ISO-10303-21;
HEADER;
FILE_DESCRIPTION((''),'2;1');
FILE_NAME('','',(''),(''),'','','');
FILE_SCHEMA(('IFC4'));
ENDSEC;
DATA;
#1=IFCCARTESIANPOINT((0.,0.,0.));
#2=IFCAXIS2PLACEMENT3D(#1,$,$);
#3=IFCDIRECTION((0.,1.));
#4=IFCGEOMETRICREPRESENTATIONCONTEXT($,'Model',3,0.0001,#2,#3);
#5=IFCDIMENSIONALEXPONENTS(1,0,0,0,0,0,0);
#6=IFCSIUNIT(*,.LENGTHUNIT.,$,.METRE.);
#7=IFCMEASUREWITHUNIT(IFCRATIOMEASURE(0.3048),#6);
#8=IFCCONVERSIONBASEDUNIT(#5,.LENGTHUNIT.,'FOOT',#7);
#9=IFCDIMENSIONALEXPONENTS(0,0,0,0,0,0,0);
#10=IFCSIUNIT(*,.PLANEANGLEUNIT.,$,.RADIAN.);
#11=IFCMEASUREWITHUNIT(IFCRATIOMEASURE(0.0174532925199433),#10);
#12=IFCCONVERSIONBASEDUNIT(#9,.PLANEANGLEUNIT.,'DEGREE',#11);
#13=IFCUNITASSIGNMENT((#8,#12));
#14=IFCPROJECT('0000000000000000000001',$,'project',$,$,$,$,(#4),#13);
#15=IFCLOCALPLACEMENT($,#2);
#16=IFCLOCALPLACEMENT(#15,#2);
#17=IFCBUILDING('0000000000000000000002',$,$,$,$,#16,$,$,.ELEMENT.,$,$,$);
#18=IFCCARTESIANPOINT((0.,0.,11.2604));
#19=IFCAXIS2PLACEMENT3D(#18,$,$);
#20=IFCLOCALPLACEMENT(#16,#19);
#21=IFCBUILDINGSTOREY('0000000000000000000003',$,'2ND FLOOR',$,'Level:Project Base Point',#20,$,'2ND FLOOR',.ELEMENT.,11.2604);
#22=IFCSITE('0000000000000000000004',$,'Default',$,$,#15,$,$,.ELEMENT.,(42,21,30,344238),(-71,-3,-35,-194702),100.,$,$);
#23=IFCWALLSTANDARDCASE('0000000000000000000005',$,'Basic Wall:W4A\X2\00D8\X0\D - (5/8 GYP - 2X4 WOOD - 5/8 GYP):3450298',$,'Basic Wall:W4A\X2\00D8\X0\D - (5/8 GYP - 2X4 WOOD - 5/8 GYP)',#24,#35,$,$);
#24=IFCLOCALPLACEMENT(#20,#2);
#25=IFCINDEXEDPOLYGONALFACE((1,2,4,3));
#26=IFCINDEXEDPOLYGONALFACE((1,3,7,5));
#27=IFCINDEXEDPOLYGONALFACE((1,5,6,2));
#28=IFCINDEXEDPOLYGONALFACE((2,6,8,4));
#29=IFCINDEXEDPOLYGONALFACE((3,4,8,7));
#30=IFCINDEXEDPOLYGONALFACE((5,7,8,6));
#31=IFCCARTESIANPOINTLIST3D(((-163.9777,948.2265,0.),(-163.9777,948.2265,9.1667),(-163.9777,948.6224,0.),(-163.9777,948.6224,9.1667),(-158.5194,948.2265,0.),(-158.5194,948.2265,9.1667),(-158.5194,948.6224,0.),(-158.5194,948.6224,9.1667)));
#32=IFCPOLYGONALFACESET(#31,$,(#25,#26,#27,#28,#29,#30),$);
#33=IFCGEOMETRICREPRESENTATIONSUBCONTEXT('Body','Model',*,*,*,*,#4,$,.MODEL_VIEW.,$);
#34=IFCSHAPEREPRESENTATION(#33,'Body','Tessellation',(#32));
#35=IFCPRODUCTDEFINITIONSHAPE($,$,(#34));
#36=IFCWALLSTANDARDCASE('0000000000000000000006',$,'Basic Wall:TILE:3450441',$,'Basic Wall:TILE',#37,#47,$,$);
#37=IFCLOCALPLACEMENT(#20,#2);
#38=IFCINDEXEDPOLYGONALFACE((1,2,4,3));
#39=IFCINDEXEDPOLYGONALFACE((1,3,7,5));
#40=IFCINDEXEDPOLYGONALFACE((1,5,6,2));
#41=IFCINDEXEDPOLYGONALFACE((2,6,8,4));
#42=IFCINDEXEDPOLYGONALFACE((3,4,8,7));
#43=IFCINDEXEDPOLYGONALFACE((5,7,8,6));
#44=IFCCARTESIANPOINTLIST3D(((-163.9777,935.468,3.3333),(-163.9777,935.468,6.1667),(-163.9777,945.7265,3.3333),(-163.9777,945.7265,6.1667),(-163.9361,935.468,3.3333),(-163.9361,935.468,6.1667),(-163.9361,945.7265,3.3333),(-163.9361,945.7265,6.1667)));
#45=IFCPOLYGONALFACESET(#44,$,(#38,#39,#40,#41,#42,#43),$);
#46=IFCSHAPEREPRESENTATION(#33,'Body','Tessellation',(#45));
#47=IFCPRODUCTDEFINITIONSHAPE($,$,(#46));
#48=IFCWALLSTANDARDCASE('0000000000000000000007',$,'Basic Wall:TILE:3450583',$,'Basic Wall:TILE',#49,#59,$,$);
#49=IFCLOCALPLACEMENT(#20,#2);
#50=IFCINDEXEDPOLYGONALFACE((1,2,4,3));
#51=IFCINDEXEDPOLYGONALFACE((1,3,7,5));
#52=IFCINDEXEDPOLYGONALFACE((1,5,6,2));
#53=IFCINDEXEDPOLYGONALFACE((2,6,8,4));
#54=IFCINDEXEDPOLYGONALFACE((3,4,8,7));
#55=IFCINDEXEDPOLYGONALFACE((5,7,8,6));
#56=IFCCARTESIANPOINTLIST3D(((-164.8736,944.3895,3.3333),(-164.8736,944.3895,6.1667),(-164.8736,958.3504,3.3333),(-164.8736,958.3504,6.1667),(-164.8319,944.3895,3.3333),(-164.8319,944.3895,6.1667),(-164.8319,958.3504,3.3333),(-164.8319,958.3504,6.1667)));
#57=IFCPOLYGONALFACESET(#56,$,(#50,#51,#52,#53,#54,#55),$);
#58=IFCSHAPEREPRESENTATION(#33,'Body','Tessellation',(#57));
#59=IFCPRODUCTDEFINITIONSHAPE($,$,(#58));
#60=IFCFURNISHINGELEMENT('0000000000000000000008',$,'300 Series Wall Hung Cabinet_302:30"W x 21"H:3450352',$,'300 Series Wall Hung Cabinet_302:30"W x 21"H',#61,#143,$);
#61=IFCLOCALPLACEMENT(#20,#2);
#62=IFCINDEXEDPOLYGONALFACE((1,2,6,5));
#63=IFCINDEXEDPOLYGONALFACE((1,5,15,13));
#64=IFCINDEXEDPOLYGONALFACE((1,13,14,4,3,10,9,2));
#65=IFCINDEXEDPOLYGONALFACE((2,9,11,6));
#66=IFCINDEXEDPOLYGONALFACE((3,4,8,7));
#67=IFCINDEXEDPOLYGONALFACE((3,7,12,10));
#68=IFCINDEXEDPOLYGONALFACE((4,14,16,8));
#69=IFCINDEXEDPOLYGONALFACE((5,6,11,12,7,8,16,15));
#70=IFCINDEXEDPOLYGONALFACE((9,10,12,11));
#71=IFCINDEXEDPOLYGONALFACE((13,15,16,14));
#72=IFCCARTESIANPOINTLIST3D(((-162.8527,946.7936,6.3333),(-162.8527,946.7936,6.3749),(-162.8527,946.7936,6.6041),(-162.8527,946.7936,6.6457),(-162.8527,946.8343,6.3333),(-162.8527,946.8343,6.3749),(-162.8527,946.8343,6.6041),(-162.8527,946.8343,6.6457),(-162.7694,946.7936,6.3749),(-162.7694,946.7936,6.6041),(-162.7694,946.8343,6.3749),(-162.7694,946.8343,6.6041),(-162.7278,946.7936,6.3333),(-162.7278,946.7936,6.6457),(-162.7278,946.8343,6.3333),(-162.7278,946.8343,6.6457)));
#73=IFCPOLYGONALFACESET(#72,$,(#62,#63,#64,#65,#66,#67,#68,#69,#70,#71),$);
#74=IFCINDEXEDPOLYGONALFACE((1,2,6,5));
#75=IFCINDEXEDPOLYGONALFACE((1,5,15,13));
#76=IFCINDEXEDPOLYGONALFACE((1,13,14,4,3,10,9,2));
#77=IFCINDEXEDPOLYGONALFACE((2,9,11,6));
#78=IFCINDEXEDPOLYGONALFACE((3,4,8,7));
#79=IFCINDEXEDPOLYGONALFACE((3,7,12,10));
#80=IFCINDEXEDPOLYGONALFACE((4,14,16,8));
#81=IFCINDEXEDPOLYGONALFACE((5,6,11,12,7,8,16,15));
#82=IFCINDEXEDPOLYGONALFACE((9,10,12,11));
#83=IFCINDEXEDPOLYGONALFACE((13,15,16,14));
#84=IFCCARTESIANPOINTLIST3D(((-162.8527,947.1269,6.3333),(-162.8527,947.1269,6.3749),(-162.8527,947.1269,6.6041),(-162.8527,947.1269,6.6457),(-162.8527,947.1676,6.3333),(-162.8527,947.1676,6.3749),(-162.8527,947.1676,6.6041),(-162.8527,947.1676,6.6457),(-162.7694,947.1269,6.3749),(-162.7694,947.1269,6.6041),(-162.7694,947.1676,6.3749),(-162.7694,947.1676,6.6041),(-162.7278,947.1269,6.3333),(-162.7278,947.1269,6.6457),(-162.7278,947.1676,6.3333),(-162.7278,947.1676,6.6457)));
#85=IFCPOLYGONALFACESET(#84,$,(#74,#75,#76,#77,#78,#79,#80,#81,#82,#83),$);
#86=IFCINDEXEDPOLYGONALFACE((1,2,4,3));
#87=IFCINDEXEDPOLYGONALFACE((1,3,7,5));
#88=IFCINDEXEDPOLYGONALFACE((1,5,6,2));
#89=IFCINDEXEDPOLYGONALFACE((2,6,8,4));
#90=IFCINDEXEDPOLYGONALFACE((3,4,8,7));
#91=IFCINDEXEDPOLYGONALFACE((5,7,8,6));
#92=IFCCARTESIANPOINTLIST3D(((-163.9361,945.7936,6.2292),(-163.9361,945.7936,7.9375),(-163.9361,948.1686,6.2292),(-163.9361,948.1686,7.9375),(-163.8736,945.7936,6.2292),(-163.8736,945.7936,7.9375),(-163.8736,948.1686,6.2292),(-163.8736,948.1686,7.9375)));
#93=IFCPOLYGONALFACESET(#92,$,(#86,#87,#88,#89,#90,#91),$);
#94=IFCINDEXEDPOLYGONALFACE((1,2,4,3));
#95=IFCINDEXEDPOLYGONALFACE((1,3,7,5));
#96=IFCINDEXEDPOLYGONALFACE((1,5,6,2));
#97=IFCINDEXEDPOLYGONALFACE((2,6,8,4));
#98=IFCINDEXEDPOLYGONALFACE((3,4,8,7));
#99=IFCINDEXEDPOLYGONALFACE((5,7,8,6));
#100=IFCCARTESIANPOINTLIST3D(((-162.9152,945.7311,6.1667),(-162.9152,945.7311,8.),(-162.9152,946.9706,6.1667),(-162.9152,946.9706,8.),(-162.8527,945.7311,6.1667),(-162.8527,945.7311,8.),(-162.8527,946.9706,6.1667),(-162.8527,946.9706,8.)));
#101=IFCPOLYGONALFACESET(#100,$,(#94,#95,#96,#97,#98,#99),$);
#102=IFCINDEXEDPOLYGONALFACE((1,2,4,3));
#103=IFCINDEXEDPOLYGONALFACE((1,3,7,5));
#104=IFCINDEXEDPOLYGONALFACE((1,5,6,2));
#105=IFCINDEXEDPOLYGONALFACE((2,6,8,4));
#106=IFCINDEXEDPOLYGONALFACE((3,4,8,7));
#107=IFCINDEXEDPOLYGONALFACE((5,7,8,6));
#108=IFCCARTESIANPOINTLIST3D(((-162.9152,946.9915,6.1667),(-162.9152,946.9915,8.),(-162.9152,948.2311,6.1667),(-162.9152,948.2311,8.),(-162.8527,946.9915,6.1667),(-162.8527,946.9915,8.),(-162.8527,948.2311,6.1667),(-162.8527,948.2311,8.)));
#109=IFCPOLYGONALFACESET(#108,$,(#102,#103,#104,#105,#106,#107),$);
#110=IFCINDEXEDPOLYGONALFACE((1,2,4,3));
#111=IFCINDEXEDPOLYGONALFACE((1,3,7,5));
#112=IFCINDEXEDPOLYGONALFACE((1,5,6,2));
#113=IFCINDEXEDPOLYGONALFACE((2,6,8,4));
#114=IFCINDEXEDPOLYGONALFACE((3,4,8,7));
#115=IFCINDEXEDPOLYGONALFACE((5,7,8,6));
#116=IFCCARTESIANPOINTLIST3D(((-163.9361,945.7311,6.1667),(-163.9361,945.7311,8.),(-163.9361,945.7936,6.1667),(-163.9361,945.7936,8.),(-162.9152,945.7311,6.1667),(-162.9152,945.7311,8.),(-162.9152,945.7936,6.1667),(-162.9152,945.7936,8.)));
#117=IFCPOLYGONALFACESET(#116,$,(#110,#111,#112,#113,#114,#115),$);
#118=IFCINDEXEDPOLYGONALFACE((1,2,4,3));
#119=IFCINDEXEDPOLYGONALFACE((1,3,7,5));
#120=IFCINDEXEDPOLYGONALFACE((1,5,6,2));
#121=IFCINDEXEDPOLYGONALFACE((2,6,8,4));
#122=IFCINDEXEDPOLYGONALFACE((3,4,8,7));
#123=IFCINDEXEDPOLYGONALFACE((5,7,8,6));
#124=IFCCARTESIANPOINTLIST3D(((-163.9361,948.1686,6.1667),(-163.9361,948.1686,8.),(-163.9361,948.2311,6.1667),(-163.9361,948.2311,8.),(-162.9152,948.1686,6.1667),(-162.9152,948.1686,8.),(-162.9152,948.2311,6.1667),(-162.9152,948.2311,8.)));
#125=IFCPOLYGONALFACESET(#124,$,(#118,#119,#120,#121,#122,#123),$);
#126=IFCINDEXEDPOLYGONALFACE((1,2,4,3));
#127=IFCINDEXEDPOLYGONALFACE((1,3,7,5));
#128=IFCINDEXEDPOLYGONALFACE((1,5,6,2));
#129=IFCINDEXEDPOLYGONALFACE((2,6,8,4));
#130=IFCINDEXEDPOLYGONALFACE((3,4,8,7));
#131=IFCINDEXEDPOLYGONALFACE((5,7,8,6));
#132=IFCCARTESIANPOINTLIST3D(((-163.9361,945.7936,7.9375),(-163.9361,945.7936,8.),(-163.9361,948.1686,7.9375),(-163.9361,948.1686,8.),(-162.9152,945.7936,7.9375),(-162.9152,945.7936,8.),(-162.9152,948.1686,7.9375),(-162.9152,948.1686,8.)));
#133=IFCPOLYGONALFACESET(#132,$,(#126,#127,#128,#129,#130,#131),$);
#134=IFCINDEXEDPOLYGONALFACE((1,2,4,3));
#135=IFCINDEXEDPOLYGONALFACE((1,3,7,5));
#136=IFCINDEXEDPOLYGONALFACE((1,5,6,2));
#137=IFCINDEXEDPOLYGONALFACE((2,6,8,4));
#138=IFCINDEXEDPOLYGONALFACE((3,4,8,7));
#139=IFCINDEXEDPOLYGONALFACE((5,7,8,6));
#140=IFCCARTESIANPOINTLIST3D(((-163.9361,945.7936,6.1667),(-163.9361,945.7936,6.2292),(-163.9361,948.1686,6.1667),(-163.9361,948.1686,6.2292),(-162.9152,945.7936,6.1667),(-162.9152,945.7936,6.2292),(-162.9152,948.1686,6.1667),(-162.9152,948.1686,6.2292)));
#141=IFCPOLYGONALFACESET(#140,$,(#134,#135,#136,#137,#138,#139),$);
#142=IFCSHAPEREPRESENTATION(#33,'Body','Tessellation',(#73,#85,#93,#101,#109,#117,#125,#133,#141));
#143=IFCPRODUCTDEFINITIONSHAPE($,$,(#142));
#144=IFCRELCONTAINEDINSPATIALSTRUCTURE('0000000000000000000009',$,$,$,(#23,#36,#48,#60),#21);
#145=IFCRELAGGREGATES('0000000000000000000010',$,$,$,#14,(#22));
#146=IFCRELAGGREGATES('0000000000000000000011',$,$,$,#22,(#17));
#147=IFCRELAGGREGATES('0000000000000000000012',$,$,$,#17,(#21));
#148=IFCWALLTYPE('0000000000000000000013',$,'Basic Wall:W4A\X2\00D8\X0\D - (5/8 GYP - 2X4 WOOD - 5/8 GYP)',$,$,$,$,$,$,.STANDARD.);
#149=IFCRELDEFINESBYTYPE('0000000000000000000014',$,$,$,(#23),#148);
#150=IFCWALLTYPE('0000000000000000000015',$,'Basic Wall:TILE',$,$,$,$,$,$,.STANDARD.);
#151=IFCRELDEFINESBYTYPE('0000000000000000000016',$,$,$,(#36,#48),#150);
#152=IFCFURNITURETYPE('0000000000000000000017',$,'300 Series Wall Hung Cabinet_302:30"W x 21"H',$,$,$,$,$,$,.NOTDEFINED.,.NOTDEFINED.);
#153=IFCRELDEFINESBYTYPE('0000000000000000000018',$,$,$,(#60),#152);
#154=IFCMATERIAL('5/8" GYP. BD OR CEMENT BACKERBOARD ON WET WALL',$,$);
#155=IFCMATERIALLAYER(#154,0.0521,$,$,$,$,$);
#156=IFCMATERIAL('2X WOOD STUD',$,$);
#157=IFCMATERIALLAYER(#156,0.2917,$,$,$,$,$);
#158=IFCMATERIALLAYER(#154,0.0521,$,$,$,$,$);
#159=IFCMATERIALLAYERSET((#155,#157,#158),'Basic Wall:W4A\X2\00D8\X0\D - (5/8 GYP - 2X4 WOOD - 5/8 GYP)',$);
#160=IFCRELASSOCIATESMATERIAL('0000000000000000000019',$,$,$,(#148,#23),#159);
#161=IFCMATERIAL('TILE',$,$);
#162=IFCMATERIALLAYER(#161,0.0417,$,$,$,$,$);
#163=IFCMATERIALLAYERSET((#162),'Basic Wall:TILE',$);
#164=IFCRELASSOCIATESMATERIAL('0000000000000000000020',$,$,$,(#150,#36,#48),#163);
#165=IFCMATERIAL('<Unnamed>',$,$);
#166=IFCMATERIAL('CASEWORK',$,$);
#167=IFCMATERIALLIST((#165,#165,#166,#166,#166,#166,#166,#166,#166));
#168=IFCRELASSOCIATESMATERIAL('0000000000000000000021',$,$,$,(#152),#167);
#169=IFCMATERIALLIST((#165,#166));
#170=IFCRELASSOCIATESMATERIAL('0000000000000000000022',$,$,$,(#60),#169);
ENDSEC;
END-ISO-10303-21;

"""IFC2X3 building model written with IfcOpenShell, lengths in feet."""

from ifc_helpers import new_model, entity, si_unit, converted_unit, direction, frame, frame_2d, origin, origin_2d_with_axis, place, context, subcontext, project, spatial, polyline, rectangle, outline, extrude, source, transform, mapped, material, material_list, layer, layer_set, layer_usage, type_object, type_shapes, element, save


model = new_model("IFC2X3")

# Units and contexts
model_context = context("Model", 3, precision=0.0001, world=origin(), true_north=direction((0.0, 1.0)))
body_context = subcontext(model_context, "Body", "Model", "MODEL_VIEW")
ifc_project = project(units=[converted_unit("LENGTHUNIT", "FOOT", entity("IfcRatioMeasure", 0.3048), si_unit("LENGTHUNIT", "METRE"), dimensions=[1, 0, 0, 0, 0, 0, 0]), converted_unit("PLANEANGLEUNIT", "DEGREE", entity("IfcRatioMeasure", 0.0174532925199433), si_unit("PLANEANGLEUNIT", "RADIAN"), dimensions=[0, 0, 0, 0, 0, 0, 0])], contexts=[model_context])

# Site, building, storey
site_placement = place(None, origin())
site = spatial("IfcSite", under=ifc_project, at=site_placement, Name="Default", CompositionType="ELEMENT", RefLatitude=(42, 21, 30, 344238), RefLongitude=(-71, -3, -35, -194702), RefElevation=100.0)
building_placement = place(site_placement, origin())
building = spatial("IfcBuilding", under=site, at=building_placement, CompositionType="ELEMENT")
storey_placement = place(building_placement, frame((0.0, 0.0, 11.2604)))
storey = spatial("IfcBuildingStorey", under=building, at=storey_placement, Name="2ND FLOOR", ObjectType="Level:Project Base Point", LongName="2ND FLOOR", CompositionType="ELEMENT", Elevation=11.2604)

# Shared definitions
ifc_material_1 = material(Name="5/8\" GYP. BD OR CEMENT BACKERBOARD ON WET WALL")
ifc_layer_1 = layer(ifc_material_1, 0.0521)
ifc_material_2 = material(Name="2X WOOD STUD")
ifc_layer_2 = layer(ifc_material_2, 0.2917)
ifc_layer_3 = layer(ifc_material_1, 0.0521)
ifc_layer_set_1 = layer_set([ifc_layer_1, ifc_layer_2, ifc_layer_3], Name="Basic Wall:W4AØD - (5/8 GYP - 2X4 WOOD - 5/8 GYP)")
wall_type_1 = type_object("IfcWallType", Name="Basic Wall:W4AØD - (5/8 GYP - 2X4 WOOD - 5/8 GYP)", PredefinedType="STANDARD", material=ifc_layer_set_1)

# Wall
ifc_layer_usage_1 = layer_usage(ifc_layer_set_1, "AXIS2", "POSITIVE", -0.1979)
wall_1_placement = place(storey_placement, frame((-158.5194, 948.4244, 0.0), z_axis=(0.0, 0.0, 1.0), x_axis=(-1.0, 0.0, 0.0)))
element("IfcWallStandardCase", 1, at=wall_1_placement, inside=storey, type_object=wall_type_1, material=ifc_layer_usage_1, Name="Basic Wall:W4AØD - (5/8 GYP - 2X4 WOOD - 5/8 GYP):3450298", ObjectType="Basic Wall:W4AØD - (5/8 GYP - 2X4 WOOD - 5/8 GYP)", context=body_context, shape_type="SweptSolid", body=[
    extrude(rectangle(XDim=5.4583, YDim=0.3958, at=frame_2d((2.7292, 0.0), x_axis=(-1.0, 0.0))), origin(), (0.0, 0.0, 1.0), 9.1667),
])

# Walls
ifc_material_3 = material(Name="TILE")
ifc_layer_4 = layer(ifc_material_3, 0.0417)
ifc_layer_set_2 = layer_set([ifc_layer_4], Name="Basic Wall:TILE")
ifc_layer_usage_2 = layer_usage(ifc_layer_set_2, "AXIS2", "POSITIVE", -0.0208)
wall_type_2 = type_object("IfcWallType", Name="Basic Wall:TILE", PredefinedType="STANDARD", material=ifc_layer_set_2)
wall_2_placement = place(storey_placement, frame((-163.9569, 945.7265, 3.3333), z_axis=(0.0, 0.0, 1.0), x_axis=(0.0, -1.0, 0.0)))
element("IfcWallStandardCase", 2, at=wall_2_placement, inside=storey, type_object=wall_type_2, material=ifc_layer_usage_2, Name="Basic Wall:TILE:3450441", ObjectType="Basic Wall:TILE", context=body_context, shape_type="SweptSolid", body=[
    extrude(rectangle(XDim=10.2585, YDim=0.0417, at=frame_2d((5.1292, 0.0), x_axis=(-1.0, 0.0))), origin(), (0.0, 0.0, 1.0), 2.8333),
])
ifc_layer_usage_3 = layer_usage(ifc_layer_set_2, "AXIS2", "NEGATIVE", 0.0208)
wall_3_placement = place(storey_placement, frame((-164.8527, 958.3504, 3.3333), z_axis=(0.0, 0.0, 1.0), x_axis=(0.0, -1.0, 0.0)))
element("IfcWallStandardCase", 3, at=wall_3_placement, inside=storey, type_object=wall_type_2, material=ifc_layer_usage_3, Name="Basic Wall:TILE:3450583", ObjectType="Basic Wall:TILE", context=body_context, shape_type="SweptSolid", body=[
    extrude(rectangle(XDim=13.9609, YDim=0.0417, at=frame_2d((6.9805, 0.0), x_axis=(-1.0, 0.0))), origin(), (0.0, 0.0, 1.0), 2.8333),
])

# Furnishing element
ifc_material_4 = material(Name="<Unnamed>")
ifc_material_5 = material(Name="CASEWORK")
ifc_material_list_1 = material_list([ifc_material_4, ifc_material_5])
ifc_material_list_2 = material_list([ifc_material_4, ifc_material_4, ifc_material_5, ifc_material_5, ifc_material_5, ifc_material_5, ifc_material_5, ifc_material_5, ifc_material_5])
furniture_type_1 = type_object("IfcFurnitureType", Name="300 Series Wall Hung Cabinet_302:30\"W x 21\"H", material=ifc_material_list_2)
shared_shape_1 = source(origin(), body_context, "Body", "SweptSolid", [
    extrude(outline(polyline([(0.1146, -0.0521), (0.1562, -0.0521), (0.1562, 0.0729), (-0.1562, 0.0729), (-0.1562, -0.0521), (-0.1146, -0.0521), (-0.1146, 0.0313), (0.1146, 0.0313), (0.1146, -0.0521)])), frame((1.0625, 0.0729, 0.3229), z_axis=(1.0, 0.0, 0.0), x_axis=(0.0, 0.0, 1.0)), (0.0, 0.0, 1.0), 0.0407),
    extrude(outline(polyline([(0.1146, -0.0521), (0.1562, -0.0521), (0.1562, 0.0729), (-0.1562, 0.0729), (-0.1562, -0.0521), (-0.1146, -0.0521), (-0.1146, 0.0313), (0.1146, 0.0313), (0.1146, -0.0521)])), frame((1.3958, 0.0729, 0.3229), z_axis=(1.0, 0.0, 0.0), x_axis=(0.0, 0.0, 1.0)), (0.0, 0.0, 1.0), 0.0407),
    extrude(rectangle(XDim=2.375, YDim=0.0625, at=origin_2d_with_axis()), frame((1.25, 1.177, 0.0625), z_axis=(0.0, 0.0, 1.0), x_axis=(-1.0, 0.0, 0.0)), (0.0, 0.0, 1.0), 1.7083),
    extrude(rectangle(XDim=1.2396, YDim=0.0625, at=origin_2d_with_axis()), frame((0.6198, 0.1562, 0.0), z_axis=(0.0, 0.0, 1.0), x_axis=(-1.0, 0.0, 0.0)), (0.0, 0.0, 1.0), 1.8333),
    extrude(rectangle(XDim=1.2396, YDim=0.0625, at=origin_2d_with_axis()), frame((1.8802, 0.1562, 0.0), z_axis=(0.0, 0.0, 1.0), x_axis=(-1.0, 0.0, 0.0)), (0.0, 0.0, 1.0), 1.8333),
    extrude(rectangle(XDim=1.0208, YDim=0.0625, at=frame_2d((0.0, 0.0), x_axis=(1.0, 0.0))), frame((0.0313, 0.6979, 0.0), z_axis=(0.0, 0.0, 1.0), x_axis=(0.0, -1.0, 0.0)), (0.0, 0.0, 1.0), 1.8333),
    extrude(rectangle(XDim=1.0208, YDim=0.0625, at=frame_2d((0.0, 0.0), x_axis=(1.0, 0.0))), frame((2.4688, 0.6979, 0.0), z_axis=(0.0, 0.0, 1.0), x_axis=(0.0, -1.0, 0.0)), (0.0, 0.0, 1.0), 1.8333),
    extrude(rectangle(XDim=1.0208, YDim=2.375, at=origin_2d_with_axis()), frame((1.25, 0.6979, 1.7708), z_axis=(0.0, 0.0, 1.0), x_axis=(0.0, 1.0, 0.0)), (0.0, 0.0, 1.0), 0.0625),
    extrude(rectangle(XDim=1.0208, YDim=2.375, at=origin_2d_with_axis()), frame((1.25, 0.6979, 0.0), z_axis=(0.0, 0.0, 1.0), x_axis=(0.0, 1.0, 0.0)), (0.0, 0.0, 1.0), 0.0625),
])
type_shapes(furniture_type_1, [shared_shape_1])
furnishing_1_placement = place(storey_placement, frame((-162.7278, 945.7311, 6.1667), z_axis=(0.0, 0.0, 1.0), x_axis=(0.0, 1.0, 0.0)))
element("IfcFurnishingElement", 4, at=furnishing_1_placement, inside=storey, type_object=furniture_type_1, material=ifc_material_list_1, Name="300 Series Wall Hung Cabinet_302:30\"W x 21\"H:3450352", ObjectType="300 Series Wall Hung Cabinet_302:30\"W x 21\"H", context=body_context, shape_type="MappedRepresentation", body=[
    mapped(shared_shape_1, transform((0.0, 0.0, 0.0), scale=1.0)),
])

save(model, "model.ifc")
